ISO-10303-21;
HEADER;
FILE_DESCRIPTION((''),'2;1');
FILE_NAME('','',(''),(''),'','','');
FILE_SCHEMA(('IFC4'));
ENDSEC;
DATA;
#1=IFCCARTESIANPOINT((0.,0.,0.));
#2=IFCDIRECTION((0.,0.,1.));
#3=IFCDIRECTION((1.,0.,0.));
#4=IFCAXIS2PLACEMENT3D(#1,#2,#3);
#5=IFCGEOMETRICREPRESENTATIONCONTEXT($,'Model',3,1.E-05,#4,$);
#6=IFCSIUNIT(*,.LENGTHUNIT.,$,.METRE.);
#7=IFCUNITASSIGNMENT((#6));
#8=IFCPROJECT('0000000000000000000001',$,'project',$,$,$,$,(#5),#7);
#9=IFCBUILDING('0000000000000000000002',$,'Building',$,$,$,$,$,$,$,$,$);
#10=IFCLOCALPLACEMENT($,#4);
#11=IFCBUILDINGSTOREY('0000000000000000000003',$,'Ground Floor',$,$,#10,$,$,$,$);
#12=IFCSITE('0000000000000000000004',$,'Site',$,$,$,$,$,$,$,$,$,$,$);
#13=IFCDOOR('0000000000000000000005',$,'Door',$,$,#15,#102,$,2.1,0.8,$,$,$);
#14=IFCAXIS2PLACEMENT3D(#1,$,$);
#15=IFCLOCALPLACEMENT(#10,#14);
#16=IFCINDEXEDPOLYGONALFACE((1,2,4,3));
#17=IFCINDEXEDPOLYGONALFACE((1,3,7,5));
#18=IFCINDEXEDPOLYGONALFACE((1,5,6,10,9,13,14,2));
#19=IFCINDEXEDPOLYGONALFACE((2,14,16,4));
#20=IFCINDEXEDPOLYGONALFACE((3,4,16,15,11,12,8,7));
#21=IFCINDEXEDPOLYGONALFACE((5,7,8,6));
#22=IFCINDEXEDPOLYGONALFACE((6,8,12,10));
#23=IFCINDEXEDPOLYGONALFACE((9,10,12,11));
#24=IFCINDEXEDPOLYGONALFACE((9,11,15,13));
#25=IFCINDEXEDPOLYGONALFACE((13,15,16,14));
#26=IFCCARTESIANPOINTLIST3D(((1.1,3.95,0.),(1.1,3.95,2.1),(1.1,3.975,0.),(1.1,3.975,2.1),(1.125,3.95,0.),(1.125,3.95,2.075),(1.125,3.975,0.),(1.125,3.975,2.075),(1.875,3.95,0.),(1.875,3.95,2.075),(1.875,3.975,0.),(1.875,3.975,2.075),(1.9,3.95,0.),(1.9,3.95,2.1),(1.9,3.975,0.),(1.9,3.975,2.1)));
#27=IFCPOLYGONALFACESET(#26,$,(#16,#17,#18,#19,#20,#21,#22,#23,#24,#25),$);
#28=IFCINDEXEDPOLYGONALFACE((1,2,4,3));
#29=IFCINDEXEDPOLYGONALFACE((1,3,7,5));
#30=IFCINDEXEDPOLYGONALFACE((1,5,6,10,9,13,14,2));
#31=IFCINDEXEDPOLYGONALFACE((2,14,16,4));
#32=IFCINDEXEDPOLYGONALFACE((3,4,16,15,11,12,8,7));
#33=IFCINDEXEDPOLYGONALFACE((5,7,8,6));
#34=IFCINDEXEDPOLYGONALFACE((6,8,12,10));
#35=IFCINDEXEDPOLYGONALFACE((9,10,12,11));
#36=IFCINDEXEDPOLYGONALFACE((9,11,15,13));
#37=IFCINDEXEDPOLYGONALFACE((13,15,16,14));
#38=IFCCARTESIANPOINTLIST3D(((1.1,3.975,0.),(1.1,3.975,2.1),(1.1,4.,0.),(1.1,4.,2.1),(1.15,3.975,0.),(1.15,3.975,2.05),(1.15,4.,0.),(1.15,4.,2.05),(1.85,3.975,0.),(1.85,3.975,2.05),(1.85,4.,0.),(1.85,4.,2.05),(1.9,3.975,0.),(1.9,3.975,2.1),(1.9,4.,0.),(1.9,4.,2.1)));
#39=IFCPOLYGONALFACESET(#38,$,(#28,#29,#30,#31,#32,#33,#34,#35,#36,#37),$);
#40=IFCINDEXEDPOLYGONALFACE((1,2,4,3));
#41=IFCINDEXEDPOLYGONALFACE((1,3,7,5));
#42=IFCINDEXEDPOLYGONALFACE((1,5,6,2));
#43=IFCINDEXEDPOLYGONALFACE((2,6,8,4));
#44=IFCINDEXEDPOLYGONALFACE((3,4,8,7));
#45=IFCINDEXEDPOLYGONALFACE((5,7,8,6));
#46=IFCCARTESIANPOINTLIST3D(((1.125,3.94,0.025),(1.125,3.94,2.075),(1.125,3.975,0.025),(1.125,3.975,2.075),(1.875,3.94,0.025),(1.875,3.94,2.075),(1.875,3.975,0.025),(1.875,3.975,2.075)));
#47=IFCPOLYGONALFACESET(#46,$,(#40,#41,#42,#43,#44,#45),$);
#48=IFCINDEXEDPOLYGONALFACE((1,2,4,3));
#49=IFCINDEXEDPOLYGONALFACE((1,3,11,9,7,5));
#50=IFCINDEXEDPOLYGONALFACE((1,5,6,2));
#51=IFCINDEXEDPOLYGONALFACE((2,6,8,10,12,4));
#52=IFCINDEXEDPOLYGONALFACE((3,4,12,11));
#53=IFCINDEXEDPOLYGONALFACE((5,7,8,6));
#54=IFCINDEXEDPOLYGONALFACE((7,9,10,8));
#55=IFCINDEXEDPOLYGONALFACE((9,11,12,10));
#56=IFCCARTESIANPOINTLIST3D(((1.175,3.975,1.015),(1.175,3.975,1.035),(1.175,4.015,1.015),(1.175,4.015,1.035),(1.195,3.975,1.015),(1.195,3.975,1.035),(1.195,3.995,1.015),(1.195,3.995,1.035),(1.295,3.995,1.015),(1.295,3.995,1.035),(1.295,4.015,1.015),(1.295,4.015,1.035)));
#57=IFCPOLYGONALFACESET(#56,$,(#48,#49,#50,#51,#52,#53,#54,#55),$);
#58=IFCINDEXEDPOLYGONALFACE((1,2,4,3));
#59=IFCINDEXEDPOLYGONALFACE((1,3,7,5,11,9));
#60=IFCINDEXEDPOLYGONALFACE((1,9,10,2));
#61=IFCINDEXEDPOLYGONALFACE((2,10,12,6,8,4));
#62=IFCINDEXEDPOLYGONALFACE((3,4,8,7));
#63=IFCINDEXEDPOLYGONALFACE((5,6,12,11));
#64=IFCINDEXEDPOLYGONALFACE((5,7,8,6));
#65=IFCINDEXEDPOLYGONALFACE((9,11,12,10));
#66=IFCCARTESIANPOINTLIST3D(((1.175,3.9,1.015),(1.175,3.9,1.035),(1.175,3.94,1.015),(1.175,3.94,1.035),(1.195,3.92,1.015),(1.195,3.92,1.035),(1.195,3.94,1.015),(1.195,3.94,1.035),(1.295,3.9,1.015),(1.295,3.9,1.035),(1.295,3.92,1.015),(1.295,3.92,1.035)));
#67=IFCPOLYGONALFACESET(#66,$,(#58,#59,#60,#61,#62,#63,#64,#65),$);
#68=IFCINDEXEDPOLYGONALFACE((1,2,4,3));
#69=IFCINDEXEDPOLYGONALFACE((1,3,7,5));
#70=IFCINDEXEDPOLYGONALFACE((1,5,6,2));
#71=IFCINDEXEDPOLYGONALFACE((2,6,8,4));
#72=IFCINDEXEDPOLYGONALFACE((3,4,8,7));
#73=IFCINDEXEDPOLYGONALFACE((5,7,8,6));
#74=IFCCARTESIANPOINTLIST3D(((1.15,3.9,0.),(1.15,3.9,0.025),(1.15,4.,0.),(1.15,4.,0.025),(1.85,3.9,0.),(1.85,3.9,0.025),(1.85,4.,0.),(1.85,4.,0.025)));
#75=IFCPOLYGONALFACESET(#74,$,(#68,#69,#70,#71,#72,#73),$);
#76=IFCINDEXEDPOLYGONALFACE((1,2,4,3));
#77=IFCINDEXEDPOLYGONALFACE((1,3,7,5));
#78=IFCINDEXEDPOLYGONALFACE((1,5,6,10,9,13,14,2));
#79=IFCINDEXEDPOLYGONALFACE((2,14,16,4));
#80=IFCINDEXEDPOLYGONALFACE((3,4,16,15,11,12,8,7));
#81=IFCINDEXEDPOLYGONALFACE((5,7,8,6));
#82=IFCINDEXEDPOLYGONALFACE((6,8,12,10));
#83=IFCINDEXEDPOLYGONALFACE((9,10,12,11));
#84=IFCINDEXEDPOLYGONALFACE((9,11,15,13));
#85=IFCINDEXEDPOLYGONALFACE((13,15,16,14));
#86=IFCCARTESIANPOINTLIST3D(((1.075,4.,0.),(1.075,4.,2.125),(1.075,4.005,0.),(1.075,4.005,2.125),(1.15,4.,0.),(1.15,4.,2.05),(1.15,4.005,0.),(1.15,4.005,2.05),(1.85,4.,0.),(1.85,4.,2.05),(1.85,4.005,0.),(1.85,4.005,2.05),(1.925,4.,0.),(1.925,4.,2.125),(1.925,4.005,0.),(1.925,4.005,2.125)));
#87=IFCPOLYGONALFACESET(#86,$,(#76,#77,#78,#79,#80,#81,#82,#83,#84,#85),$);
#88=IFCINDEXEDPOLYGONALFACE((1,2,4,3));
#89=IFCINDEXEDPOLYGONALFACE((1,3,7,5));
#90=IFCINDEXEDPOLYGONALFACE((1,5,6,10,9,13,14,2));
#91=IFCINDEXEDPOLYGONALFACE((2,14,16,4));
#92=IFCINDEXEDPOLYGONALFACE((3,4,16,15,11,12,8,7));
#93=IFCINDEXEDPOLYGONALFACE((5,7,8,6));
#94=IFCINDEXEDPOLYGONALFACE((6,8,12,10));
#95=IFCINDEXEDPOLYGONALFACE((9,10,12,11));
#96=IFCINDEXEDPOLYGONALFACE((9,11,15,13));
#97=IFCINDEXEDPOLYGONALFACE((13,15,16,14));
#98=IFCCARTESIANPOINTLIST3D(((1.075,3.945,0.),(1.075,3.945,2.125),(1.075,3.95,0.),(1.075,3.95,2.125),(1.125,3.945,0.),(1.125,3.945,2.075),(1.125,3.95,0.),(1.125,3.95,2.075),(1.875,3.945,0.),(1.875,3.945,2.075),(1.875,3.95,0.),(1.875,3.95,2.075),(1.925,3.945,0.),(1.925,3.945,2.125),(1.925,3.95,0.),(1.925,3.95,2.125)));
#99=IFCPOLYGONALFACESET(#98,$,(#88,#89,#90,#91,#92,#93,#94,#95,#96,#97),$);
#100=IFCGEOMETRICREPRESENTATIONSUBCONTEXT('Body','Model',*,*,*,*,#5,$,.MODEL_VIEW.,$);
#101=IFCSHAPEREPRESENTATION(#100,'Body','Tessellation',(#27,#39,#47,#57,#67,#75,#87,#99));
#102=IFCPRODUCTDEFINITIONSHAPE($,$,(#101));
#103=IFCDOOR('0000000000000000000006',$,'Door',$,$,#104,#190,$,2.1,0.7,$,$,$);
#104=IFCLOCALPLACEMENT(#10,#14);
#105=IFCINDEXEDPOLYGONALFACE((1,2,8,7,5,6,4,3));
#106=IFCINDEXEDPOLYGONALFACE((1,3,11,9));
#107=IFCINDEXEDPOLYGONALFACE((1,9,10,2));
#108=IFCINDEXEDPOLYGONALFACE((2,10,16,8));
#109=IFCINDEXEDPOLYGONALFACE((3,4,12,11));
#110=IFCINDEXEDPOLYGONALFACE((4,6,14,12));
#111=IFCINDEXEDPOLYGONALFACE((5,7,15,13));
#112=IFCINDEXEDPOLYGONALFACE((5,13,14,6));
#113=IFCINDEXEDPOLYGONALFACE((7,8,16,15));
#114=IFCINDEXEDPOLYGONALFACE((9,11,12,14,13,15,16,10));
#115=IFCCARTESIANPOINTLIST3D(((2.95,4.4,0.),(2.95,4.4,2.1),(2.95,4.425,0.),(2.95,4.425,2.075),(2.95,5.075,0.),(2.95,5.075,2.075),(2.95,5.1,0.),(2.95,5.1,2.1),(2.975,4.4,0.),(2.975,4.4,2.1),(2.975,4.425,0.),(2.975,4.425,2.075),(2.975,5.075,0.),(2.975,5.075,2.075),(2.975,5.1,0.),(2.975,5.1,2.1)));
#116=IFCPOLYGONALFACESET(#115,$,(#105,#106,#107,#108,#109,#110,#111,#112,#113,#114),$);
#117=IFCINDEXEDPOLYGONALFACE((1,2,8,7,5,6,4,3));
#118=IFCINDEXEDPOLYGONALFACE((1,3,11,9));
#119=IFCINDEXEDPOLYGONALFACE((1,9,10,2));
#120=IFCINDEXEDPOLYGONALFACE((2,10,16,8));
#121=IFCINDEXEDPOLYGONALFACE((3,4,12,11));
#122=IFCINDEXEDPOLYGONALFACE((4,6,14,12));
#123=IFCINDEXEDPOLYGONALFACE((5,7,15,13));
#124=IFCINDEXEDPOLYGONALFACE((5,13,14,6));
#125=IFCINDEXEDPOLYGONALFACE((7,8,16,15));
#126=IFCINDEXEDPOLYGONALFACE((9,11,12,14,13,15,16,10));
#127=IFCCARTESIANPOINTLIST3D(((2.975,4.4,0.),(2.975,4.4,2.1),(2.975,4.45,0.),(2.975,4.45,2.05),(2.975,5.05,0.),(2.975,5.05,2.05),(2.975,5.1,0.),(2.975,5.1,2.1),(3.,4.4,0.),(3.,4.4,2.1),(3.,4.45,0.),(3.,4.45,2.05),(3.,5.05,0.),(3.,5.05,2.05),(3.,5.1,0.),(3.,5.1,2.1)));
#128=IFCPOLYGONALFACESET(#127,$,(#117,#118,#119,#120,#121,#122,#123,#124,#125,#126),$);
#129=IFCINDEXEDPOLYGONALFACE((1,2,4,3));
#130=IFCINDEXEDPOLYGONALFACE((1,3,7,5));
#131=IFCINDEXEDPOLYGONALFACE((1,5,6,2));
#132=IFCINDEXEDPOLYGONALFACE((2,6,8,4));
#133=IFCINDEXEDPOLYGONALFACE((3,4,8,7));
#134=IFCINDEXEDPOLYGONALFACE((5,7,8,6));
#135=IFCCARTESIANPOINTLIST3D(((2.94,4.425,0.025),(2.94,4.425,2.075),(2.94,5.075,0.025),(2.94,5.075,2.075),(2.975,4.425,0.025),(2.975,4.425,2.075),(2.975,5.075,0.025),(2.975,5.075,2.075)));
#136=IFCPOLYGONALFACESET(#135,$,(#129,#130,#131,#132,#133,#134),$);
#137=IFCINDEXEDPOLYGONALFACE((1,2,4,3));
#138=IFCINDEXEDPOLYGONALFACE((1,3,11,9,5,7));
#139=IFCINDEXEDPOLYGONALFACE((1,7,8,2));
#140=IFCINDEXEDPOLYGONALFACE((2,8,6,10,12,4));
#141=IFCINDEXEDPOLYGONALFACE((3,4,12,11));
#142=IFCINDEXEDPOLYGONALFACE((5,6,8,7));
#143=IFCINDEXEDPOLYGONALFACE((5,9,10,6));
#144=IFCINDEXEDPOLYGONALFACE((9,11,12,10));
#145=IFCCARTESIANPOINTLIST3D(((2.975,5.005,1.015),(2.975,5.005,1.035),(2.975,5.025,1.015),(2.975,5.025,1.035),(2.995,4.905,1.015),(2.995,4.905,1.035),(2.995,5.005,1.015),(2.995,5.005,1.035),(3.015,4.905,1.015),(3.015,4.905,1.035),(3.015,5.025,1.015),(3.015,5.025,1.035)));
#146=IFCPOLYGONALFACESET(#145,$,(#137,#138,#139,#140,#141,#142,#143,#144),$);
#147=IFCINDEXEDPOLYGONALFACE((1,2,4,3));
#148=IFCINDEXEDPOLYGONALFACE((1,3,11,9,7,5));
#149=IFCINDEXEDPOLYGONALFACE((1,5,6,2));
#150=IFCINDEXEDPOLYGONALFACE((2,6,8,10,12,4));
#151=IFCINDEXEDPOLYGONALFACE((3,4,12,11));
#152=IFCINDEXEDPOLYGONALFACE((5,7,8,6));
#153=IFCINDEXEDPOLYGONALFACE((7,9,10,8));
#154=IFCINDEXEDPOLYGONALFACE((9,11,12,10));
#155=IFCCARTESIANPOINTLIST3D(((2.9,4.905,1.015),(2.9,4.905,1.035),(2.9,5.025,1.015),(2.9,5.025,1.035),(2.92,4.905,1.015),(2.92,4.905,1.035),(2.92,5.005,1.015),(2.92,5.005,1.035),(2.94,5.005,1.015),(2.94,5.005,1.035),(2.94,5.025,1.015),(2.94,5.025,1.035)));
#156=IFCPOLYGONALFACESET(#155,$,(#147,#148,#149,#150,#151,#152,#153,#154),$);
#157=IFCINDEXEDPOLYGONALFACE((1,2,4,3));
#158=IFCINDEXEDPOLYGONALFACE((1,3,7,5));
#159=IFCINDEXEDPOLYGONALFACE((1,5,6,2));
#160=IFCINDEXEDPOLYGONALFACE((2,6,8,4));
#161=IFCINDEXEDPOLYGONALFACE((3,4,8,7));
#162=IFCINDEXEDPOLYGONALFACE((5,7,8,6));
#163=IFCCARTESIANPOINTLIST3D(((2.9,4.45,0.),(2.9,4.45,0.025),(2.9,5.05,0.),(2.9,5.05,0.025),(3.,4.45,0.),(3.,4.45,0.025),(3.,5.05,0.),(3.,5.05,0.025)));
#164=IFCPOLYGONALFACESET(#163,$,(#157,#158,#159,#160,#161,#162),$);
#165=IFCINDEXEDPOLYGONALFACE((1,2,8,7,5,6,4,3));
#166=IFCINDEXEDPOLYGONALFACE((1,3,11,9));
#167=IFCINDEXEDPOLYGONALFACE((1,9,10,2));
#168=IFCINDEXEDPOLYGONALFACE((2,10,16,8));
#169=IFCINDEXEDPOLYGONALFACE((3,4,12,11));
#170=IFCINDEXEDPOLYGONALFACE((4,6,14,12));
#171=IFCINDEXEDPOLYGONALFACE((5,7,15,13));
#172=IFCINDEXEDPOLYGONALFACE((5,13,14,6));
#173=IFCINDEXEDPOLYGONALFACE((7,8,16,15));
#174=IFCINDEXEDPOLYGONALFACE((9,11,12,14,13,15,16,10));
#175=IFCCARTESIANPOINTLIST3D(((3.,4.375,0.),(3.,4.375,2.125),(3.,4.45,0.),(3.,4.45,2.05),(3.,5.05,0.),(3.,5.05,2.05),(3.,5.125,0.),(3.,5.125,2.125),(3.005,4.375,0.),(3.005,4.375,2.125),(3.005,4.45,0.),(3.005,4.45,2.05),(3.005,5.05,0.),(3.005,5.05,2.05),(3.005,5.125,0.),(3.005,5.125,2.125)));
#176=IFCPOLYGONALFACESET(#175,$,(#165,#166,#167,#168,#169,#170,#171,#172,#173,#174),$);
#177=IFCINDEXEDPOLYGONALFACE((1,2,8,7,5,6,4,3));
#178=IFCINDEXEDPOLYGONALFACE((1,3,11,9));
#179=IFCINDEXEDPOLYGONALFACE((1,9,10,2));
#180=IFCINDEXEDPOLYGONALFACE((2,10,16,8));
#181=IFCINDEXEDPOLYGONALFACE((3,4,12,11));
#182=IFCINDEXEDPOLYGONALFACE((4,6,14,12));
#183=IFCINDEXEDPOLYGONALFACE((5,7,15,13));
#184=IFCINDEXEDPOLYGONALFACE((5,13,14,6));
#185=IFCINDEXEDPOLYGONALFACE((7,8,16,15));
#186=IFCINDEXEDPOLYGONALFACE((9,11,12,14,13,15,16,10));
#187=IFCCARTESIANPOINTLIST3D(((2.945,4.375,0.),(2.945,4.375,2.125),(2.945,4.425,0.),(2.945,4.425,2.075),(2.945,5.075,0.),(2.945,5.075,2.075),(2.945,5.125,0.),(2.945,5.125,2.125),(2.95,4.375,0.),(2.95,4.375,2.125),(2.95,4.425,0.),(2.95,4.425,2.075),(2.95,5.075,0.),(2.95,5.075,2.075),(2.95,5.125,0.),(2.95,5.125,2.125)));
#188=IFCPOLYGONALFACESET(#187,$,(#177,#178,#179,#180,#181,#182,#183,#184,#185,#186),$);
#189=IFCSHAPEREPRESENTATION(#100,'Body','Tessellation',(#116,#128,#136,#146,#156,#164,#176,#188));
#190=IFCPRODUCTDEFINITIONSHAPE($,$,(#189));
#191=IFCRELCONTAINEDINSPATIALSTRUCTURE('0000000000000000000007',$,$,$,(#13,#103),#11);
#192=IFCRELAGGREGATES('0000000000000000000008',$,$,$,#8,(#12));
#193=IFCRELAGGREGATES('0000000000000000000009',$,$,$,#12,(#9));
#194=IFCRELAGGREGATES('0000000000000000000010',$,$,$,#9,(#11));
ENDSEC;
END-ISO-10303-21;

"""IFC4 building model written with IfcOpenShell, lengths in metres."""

from ifc_helpers import new_model, si_unit, frame, origin_with_axes, place, context, subcontext, project, spatial, line, indexed_curve, outline, extrude, element, save


model = new_model("IFC4")

# Units and contexts
model_context = context("Model", 3, precision=1e-05, world=origin_with_axes())
body_context = subcontext(model_context, "Body", "Model", "MODEL_VIEW")
ifc_project = project(units=[si_unit("LENGTHUNIT", "METRE")], contexts=[model_context])

# Site, building, storey
site = spatial("IfcSite", under=ifc_project, Name="Site")
building = spatial("IfcBuilding", under=site, Name="Building")
storey_placement = place(None, origin_with_axes())
storey = spatial("IfcBuildingStorey", under=building, at=storey_placement, Name="Ground Floor")

# Doors
door_1_placement = place(storey_placement, frame((1.9, 4.0, 0.0), z_axis=(0.0, 0.0, 1.0), x_axis=(-1.0, 0.0, 0.0)))
element("IfcDoor", 1, at=door_1_placement, inside=storey, Name="Door", OverallHeight=2.1, OverallWidth=0.8, context=body_context, shape_type="SweptSolid", body=[
    extrude(outline(indexed_curve([(0.0, 0.0), (0.0, 2.1), (0.8, 2.1), (0.8, 0.0), (0.775, 0.0), (0.775, 2.075), (0.025, 2.075), (0.025, 0.0)], segments=[line(1, 2, 3, 4, 5, 6, 7, 8, 1)])), frame((0.0, 0.025, 0.0), z_axis=(0.0, -1.0, 0.0), x_axis=(1.0, 0.0, 0.0)), (0.0, 0.0, -1.0), 0.025),
    extrude(outline(indexed_curve([(0.0, 0.0), (0.0, 2.1), (0.8, 2.1), (0.8, 0.0), (0.75, 0.0), (0.75, 2.05), (0.05, 2.05), (0.05, 0.0)], segments=[line(1, 2, 3, 4, 5, 6, 7, 8, 1)])), frame((0.0, 0.0, 0.0), z_axis=(0.0, -1.0, 0.0), x_axis=(1.0, 0.0, 0.0)), (0.0, 0.0, -1.0), 0.025),
    extrude(outline(indexed_curve([(0.0, 0.0), (0.75, 0.0), (0.75, 0.035), (0.0, 0.035)], segments=[line(1, 2, 3, 4, 1)])), frame((0.025, 0.025, 0.025), z_axis=(0.0, 0.0, 1.0), x_axis=(1.0, 0.0, 0.0)), (0.0, 0.0, 1.0), 2.05),
    extrude(outline(indexed_curve([(0.0, 0.0), (0.0, -0.04), (-0.12, -0.04), (-0.12, -0.02), (-0.02, -0.02), (-0.02, 0.0)], segments=[line(1, 2, 3, 4, 5, 6, 1)])), frame((0.725, 0.025, 1.015), z_axis=(0.0, 0.0, 1.0), x_axis=(1.0, 0.0, 0.0)), (0.0, 0.0, 1.0), 0.02),
    extrude(outline(indexed_curve([(0.0, 0.0), (0.0, 0.04), (-0.12, 0.04), (-0.12, 0.02), (-0.02, 0.02), (-0.02, 0.0)], segments=[line(1, 2, 3, 4, 5, 6, 1)])), frame((0.725, 0.06, 1.015), z_axis=(0.0, 0.0, 1.0), x_axis=(1.0, 0.0, 0.0)), (0.0, 0.0, 1.0), 0.02),
    extrude(outline(indexed_curve([(0.0, 0.0), (0.7, 0.0), (0.7, 0.1), (0.0, 0.1)], segments=[line(1, 2, 3, 4, 1)])), frame((0.05, 0.0, 0.0), z_axis=(0.0, 0.0, 1.0), x_axis=(1.0, 0.0, 0.0)), (0.0, 0.0, 1.0), 0.025),
    extrude(outline(indexed_curve([(0.0, 0.0), (0.0, 2.125), (0.85, 2.125), (0.85, 0.0), (0.775, 0.0), (0.775, 2.05), (0.075, 2.05), (0.075, 0.0)], segments=[line(1, 2, 3, 4, 5, 6, 7, 8, 1)])), frame((-0.025, -0.005, 0.0), z_axis=(0.0, -1.0, 0.0), x_axis=(1.0, 0.0, 0.0)), (0.0, 0.0, -1.0), 0.005),
    extrude(outline(indexed_curve([(0.0, 0.0), (0.0, 2.125), (0.85, 2.125), (0.85, 0.0), (0.8, 0.0), (0.8, 2.075), (0.05, 2.075), (0.05, 0.0)], segments=[line(1, 2, 3, 4, 5, 6, 7, 8, 1)])), frame((-0.025, 0.05, 0.0), z_axis=(0.0, -1.0, 0.0), x_axis=(1.0, 0.0, 0.0)), (0.0, 0.0, -1.0), 0.005),
])
door_2_placement = place(storey_placement, frame((3.0, 4.4, 0.0), z_axis=(0.0, 0.0, 1.0), x_axis=(0.0, 1.0, 0.0)))
element("IfcDoor", 2, at=door_2_placement, inside=storey, Name="Door", OverallHeight=2.1, OverallWidth=0.7, context=body_context, shape_type="SweptSolid", body=[
    extrude(outline(indexed_curve([(0.0, 0.0), (0.0, 2.1), (0.7, 2.1), (0.7, 0.0), (0.675, 0.0), (0.675, 2.075), (0.025, 2.075), (0.025, 0.0)], segments=[line(1, 2, 3, 4, 5, 6, 7, 8, 1)])), frame((0.0, 0.025, 0.0), z_axis=(0.0, -1.0, 0.0), x_axis=(1.0, 0.0, 0.0)), (0.0, 0.0, -1.0), 0.025),
    extrude(outline(indexed_curve([(0.0, 0.0), (0.0, 2.1), (0.7, 2.1), (0.7, 0.0), (0.65, 0.0), (0.65, 2.05), (0.05, 2.05), (0.05, 0.0)], segments=[line(1, 2, 3, 4, 5, 6, 7, 8, 1)])), frame((0.0, 0.0, 0.0), z_axis=(0.0, -1.0, 0.0), x_axis=(1.0, 0.0, 0.0)), (0.0, 0.0, -1.0), 0.025),
    extrude(outline(indexed_curve([(0.0, 0.0), (0.65, 0.0), (0.65, 0.035), (0.0, 0.035)], segments=[line(1, 2, 3, 4, 1)])), frame((0.025, 0.025, 0.025), z_axis=(0.0, 0.0, 1.0), x_axis=(1.0, 0.0, 0.0)), (0.0, 0.0, 1.0), 2.05),
    extrude(outline(indexed_curve([(0.0, 0.0), (0.0, -0.04), (-0.12, -0.04), (-0.12, -0.02), (-0.02, -0.02), (-0.02, 0.0)], segments=[line(1, 2, 3, 4, 5, 6, 1)])), frame((0.625, 0.025, 1.015), z_axis=(0.0, 0.0, 1.0), x_axis=(1.0, 0.0, 0.0)), (0.0, 0.0, 1.0), 0.02),
    extrude(outline(indexed_curve([(0.0, 0.0), (0.0, 0.04), (-0.12, 0.04), (-0.12, 0.02), (-0.02, 0.02), (-0.02, 0.0)], segments=[line(1, 2, 3, 4, 5, 6, 1)])), frame((0.625, 0.06, 1.015), z_axis=(0.0, 0.0, 1.0), x_axis=(1.0, 0.0, 0.0)), (0.0, 0.0, 1.0), 0.02),
    extrude(outline(indexed_curve([(0.0, 0.0), (0.6, 0.0), (0.6, 0.1), (0.0, 0.1)], segments=[line(1, 2, 3, 4, 1)])), frame((0.05, 0.0, 0.0), z_axis=(0.0, 0.0, 1.0), x_axis=(1.0, 0.0, 0.0)), (0.0, 0.0, 1.0), 0.025),
    extrude(outline(indexed_curve([(0.0, 0.0), (0.0, 2.125), (0.75, 2.125), (0.75, 0.0), (0.675, 0.0), (0.675, 2.05), (0.075, 2.05), (0.075, 0.0)], segments=[line(1, 2, 3, 4, 5, 6, 7, 8, 1)])), frame((-0.025, -0.005, 0.0), z_axis=(0.0, -1.0, 0.0), x_axis=(1.0, 0.0, 0.0)), (0.0, 0.0, -1.0), 0.005),
    extrude(outline(indexed_curve([(0.0, 0.0), (0.0, 2.125), (0.75, 2.125), (0.75, 0.0), (0.7, 0.0), (0.7, 2.075), (0.05, 2.075), (0.05, 0.0)], segments=[line(1, 2, 3, 4, 5, 6, 7, 8, 1)])), frame((-0.025, 0.05, 0.0), z_axis=(0.0, -1.0, 0.0), x_axis=(1.0, 0.0, 0.0)), (0.0, 0.0, -1.0), 0.005),
])

save(model, "model.ifc")
